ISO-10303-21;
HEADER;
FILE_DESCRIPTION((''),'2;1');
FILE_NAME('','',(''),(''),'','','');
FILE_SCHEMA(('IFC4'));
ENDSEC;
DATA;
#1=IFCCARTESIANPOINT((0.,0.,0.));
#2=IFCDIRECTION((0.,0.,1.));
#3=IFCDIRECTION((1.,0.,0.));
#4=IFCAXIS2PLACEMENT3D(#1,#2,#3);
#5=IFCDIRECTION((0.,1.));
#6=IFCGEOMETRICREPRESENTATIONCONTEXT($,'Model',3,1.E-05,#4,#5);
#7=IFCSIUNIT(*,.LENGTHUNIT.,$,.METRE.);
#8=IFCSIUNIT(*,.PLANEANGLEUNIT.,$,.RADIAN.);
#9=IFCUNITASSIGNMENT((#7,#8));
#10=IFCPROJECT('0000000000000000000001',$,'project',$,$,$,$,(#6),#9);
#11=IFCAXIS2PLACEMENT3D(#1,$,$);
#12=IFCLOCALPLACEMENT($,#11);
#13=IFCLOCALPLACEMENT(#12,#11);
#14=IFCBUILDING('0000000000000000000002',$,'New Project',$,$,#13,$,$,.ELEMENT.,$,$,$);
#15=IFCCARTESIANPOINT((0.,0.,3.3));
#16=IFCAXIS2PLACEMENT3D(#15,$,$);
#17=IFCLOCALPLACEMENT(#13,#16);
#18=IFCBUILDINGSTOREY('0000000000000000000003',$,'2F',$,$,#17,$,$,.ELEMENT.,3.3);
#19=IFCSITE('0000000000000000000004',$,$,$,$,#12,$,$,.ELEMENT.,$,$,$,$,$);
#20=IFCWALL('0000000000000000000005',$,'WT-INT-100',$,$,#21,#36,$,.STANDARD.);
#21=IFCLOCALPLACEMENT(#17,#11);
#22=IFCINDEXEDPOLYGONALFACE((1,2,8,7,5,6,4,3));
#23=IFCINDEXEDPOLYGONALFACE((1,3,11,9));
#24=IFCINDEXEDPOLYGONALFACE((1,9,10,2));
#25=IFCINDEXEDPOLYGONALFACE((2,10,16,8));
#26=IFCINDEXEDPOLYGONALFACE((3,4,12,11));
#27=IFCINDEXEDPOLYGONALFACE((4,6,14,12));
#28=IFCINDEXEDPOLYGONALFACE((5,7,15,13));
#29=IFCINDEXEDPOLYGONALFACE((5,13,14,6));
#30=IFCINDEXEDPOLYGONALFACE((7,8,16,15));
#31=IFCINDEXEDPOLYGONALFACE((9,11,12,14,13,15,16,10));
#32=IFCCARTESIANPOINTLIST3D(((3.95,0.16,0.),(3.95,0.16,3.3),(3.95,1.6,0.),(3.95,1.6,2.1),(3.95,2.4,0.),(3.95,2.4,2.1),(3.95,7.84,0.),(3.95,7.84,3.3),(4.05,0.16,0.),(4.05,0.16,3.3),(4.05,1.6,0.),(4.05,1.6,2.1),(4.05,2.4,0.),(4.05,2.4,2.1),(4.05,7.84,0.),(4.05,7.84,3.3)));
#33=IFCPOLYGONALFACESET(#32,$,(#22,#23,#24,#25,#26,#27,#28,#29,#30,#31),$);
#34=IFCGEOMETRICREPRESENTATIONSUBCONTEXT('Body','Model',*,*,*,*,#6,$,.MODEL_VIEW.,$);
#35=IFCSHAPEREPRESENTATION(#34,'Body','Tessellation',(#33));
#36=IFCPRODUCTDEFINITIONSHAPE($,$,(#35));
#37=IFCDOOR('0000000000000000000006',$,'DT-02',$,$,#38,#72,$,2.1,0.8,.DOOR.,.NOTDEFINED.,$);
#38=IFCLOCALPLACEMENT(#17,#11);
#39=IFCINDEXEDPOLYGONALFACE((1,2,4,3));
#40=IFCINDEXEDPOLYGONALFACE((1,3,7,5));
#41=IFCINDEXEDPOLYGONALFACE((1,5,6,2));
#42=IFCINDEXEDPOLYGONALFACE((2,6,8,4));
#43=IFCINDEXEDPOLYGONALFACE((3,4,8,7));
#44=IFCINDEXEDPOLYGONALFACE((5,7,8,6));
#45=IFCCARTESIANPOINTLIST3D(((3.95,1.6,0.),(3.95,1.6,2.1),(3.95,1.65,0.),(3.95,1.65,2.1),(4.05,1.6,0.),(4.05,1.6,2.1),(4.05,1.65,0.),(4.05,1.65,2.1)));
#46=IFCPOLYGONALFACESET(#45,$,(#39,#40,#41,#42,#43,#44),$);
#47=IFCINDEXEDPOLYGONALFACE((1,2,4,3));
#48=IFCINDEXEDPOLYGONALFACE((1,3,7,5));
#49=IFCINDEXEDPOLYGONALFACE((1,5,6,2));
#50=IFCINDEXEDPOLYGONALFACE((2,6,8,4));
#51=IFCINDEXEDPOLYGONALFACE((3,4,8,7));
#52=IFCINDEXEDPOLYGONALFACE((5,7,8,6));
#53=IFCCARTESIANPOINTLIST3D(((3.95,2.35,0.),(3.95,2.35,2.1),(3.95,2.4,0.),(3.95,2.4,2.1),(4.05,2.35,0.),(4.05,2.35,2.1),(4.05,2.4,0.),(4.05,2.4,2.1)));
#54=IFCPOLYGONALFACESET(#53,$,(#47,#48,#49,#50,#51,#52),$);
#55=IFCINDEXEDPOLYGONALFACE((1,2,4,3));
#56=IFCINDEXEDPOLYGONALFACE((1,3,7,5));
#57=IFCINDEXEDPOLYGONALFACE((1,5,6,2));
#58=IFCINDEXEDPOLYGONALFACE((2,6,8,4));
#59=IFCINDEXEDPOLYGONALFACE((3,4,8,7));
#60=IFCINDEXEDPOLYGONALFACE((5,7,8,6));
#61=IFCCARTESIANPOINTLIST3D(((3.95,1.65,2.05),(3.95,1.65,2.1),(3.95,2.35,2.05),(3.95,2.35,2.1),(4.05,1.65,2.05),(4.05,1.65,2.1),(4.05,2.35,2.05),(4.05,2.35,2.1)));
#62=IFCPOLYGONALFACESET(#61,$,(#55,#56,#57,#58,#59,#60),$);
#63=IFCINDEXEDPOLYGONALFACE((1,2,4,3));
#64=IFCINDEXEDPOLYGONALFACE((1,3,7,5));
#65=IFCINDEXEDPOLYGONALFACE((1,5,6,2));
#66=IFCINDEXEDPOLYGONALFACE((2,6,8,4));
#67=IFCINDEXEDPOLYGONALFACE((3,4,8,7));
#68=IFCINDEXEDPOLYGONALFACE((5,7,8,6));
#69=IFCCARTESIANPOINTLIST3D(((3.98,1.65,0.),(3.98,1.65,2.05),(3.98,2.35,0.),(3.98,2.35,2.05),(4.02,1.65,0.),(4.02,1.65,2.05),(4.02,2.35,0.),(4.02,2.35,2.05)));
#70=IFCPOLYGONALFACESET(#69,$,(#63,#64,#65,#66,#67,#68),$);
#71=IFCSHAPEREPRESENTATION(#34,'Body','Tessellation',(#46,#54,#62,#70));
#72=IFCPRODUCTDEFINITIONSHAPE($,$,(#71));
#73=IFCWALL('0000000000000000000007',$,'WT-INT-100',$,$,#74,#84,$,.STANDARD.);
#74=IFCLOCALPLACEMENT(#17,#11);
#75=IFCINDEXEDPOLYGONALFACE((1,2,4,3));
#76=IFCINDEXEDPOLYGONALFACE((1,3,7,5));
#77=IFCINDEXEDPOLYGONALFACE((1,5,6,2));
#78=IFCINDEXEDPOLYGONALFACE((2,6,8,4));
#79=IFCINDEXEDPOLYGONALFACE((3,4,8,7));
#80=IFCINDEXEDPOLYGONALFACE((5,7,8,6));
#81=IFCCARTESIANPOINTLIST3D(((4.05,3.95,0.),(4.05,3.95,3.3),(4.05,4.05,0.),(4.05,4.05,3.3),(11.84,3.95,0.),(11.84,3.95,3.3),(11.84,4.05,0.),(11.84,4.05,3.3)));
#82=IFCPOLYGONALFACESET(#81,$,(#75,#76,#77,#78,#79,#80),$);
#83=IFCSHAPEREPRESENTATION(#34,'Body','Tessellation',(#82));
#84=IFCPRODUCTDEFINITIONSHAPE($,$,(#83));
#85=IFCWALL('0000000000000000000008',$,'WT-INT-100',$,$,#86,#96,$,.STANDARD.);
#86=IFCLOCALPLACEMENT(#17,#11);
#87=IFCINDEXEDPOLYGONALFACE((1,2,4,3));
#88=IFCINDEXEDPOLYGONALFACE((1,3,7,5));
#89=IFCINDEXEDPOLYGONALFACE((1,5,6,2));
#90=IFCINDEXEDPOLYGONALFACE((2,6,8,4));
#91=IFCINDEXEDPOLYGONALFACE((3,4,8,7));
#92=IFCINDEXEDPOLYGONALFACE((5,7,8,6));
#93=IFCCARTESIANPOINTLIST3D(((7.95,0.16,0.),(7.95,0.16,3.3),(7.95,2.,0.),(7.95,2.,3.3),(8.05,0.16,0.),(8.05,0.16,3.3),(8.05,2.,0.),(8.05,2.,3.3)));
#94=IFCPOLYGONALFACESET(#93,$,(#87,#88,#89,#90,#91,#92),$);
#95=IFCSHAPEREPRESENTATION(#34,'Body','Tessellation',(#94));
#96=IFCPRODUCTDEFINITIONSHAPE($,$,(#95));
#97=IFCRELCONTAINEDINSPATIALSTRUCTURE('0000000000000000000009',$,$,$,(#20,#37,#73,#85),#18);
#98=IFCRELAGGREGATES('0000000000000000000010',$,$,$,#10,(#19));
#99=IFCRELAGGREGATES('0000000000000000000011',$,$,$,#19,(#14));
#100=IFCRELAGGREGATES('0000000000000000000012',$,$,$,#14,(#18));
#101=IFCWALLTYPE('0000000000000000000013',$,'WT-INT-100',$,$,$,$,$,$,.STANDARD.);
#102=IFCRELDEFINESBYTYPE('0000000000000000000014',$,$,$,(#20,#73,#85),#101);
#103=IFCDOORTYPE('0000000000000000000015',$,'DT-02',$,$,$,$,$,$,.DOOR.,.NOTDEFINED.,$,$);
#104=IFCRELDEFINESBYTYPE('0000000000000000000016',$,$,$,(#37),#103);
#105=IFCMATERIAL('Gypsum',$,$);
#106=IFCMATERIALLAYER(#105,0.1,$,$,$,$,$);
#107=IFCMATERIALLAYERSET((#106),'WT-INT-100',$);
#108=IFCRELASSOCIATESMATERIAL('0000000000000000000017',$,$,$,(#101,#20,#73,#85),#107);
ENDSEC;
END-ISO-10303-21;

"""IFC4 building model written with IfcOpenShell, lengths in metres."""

from ifc_helpers import new_model, si_unit, direction, frame, frame_2d, origin, origin_with_axes, place, context, subcontext, project, spatial, polyline, rectangle, outline, extrude, material, layer, layer_set, layer_usage, type_object, element, fill, save


model = new_model("IFC4")

# Units and contexts
model_context = context("Model", 3, precision=1e-05, world=origin_with_axes(), true_north=direction((0.0, 1.0)))
body_context = subcontext(model_context, "Body", "Model", "MODEL_VIEW")
ifc_project = project(units=[si_unit("LENGTHUNIT", "METRE"), si_unit("PLANEANGLEUNIT", "RADIAN")], contexts=[model_context])

# Site, building, storey
site_placement = place(None, origin())
site = spatial("IfcSite", under=ifc_project, at=site_placement, CompositionType="ELEMENT")
building_placement = place(site_placement, origin())
building = spatial("IfcBuilding", under=site, at=building_placement, Name="New Project", CompositionType="ELEMENT")
storey_placement = place(building_placement, frame((0.0, 0.0, 3.3)))
storey = spatial("IfcBuildingStorey", under=building, at=storey_placement, Name="2F", CompositionType="ELEMENT", Elevation=3.3)

# Wall, opening, door
ifc_material_1 = material(Name="Gypsum")
ifc_layer_1 = layer(ifc_material_1, 0.1)
ifc_layer_set_1 = layer_set([ifc_layer_1], Name="WT-INT-100")
ifc_layer_usage_1 = layer_usage(ifc_layer_set_1, "AXIS2", "NEGATIVE", 0.05)
wall_type_1 = type_object("IfcWallType", Name="WT-INT-100", PredefinedType="STANDARD", material=ifc_layer_set_1)
wall_1_placement = place(storey_placement, frame((4.0, 0.16, 0.0), z_axis=(0.0, 0.0, 1.0), x_axis=(0.0, 1.0, 0.0)))
wall_1 = element("IfcWall", 1, at=wall_1_placement, inside=storey, type_object=wall_type_1, material=ifc_layer_usage_1, Name="WT-INT-100", PredefinedType="STANDARD", context=body_context, shape_type="SweptSolid", body=[
    extrude(outline(polyline([(0.0, -0.05), (7.68, -0.05), (7.68, 0.05), (0.0, 0.05), (0.0, -0.05)])), origin(), (0.0, 0.0, 1.0), 3.3),
])
opening_1_placement = place(wall_1_placement, frame((1.44, 0.0, 0.0)))
opening_1 = element("IfcOpeningElement", 2, at=opening_1_placement, cuts=wall_1, PredefinedType="OPENING", context=body_context, shape_type="SweptSolid", body=[
    extrude(rectangle(XDim=0.8, YDim=0.2, at=frame_2d((0.4, 0.0))), origin(), (0.0, 0.0, 1.0), 2.1),
])
door_type_1 = type_object("IfcDoorType", Name="DT-02", OperationType="NOTDEFINED", PredefinedType="DOOR")
door_1_placement = place(opening_1_placement, origin())
door_1 = element("IfcDoor", 3, at=door_1_placement, inside=storey, type_object=door_type_1, Name="DT-02", OperationType="NOTDEFINED", OverallHeight=2.1, OverallWidth=0.8, PredefinedType="DOOR", context=body_context, shape_type="SweptSolid", body=[
    extrude(outline(polyline([(0.0, -0.05), (0.05, -0.05), (0.05, 0.05), (0.0, 0.05), (0.0, -0.05)])), origin(), (0.0, 0.0, 1.0), 2.1),
    extrude(outline(polyline([(0.75, -0.05), (0.8, -0.05), (0.8, 0.05), (0.75, 0.05), (0.75, -0.05)])), origin(), (0.0, 0.0, 1.0), 2.1),
    extrude(outline(polyline([(0.05, -0.05), (0.75, -0.05), (0.75, 0.05), (0.05, 0.05), (0.05, -0.05)])), frame((0.0, 0.0, 2.05)), (0.0, 0.0, 1.0), 0.05),
    extrude(outline(polyline([(0.05, -0.02), (0.75, -0.02), (0.75, 0.02), (0.05, 0.02), (0.05, -0.02)])), origin(), (0.0, 0.0, 1.0), 2.05),
])
fill(opening_1, door_1)

# Walls
wall_2_placement = place(storey_placement, frame((4.05, 4.0, 0.0)))
element("IfcWall", 4, at=wall_2_placement, inside=storey, type_object=wall_type_1, material=ifc_layer_usage_1, Name="WT-INT-100", PredefinedType="STANDARD", context=body_context, shape_type="SweptSolid", body=[
    extrude(outline(polyline([(0.0, -0.05), (7.79, -0.05), (7.79, 0.05), (0.0, 0.05), (0.0, -0.05)])), origin(), (0.0, 0.0, 1.0), 3.3),
])
wall_3_placement = place(storey_placement, frame((8.0, 0.16, 0.0), z_axis=(0.0, 0.0, 1.0), x_axis=(0.0, 1.0, 0.0)))
element("IfcWall", 5, at=wall_3_placement, inside=storey, type_object=wall_type_1, material=ifc_layer_usage_1, Name="WT-INT-100", PredefinedType="STANDARD", context=body_context, shape_type="SweptSolid", body=[
    extrude(outline(polyline([(0.0, -0.05), (1.84, -0.05), (1.84, 0.05), (0.0, 0.05), (0.0, -0.05)])), origin(), (0.0, 0.0, 1.0), 3.3),
])

save(model, "model.ifc")
